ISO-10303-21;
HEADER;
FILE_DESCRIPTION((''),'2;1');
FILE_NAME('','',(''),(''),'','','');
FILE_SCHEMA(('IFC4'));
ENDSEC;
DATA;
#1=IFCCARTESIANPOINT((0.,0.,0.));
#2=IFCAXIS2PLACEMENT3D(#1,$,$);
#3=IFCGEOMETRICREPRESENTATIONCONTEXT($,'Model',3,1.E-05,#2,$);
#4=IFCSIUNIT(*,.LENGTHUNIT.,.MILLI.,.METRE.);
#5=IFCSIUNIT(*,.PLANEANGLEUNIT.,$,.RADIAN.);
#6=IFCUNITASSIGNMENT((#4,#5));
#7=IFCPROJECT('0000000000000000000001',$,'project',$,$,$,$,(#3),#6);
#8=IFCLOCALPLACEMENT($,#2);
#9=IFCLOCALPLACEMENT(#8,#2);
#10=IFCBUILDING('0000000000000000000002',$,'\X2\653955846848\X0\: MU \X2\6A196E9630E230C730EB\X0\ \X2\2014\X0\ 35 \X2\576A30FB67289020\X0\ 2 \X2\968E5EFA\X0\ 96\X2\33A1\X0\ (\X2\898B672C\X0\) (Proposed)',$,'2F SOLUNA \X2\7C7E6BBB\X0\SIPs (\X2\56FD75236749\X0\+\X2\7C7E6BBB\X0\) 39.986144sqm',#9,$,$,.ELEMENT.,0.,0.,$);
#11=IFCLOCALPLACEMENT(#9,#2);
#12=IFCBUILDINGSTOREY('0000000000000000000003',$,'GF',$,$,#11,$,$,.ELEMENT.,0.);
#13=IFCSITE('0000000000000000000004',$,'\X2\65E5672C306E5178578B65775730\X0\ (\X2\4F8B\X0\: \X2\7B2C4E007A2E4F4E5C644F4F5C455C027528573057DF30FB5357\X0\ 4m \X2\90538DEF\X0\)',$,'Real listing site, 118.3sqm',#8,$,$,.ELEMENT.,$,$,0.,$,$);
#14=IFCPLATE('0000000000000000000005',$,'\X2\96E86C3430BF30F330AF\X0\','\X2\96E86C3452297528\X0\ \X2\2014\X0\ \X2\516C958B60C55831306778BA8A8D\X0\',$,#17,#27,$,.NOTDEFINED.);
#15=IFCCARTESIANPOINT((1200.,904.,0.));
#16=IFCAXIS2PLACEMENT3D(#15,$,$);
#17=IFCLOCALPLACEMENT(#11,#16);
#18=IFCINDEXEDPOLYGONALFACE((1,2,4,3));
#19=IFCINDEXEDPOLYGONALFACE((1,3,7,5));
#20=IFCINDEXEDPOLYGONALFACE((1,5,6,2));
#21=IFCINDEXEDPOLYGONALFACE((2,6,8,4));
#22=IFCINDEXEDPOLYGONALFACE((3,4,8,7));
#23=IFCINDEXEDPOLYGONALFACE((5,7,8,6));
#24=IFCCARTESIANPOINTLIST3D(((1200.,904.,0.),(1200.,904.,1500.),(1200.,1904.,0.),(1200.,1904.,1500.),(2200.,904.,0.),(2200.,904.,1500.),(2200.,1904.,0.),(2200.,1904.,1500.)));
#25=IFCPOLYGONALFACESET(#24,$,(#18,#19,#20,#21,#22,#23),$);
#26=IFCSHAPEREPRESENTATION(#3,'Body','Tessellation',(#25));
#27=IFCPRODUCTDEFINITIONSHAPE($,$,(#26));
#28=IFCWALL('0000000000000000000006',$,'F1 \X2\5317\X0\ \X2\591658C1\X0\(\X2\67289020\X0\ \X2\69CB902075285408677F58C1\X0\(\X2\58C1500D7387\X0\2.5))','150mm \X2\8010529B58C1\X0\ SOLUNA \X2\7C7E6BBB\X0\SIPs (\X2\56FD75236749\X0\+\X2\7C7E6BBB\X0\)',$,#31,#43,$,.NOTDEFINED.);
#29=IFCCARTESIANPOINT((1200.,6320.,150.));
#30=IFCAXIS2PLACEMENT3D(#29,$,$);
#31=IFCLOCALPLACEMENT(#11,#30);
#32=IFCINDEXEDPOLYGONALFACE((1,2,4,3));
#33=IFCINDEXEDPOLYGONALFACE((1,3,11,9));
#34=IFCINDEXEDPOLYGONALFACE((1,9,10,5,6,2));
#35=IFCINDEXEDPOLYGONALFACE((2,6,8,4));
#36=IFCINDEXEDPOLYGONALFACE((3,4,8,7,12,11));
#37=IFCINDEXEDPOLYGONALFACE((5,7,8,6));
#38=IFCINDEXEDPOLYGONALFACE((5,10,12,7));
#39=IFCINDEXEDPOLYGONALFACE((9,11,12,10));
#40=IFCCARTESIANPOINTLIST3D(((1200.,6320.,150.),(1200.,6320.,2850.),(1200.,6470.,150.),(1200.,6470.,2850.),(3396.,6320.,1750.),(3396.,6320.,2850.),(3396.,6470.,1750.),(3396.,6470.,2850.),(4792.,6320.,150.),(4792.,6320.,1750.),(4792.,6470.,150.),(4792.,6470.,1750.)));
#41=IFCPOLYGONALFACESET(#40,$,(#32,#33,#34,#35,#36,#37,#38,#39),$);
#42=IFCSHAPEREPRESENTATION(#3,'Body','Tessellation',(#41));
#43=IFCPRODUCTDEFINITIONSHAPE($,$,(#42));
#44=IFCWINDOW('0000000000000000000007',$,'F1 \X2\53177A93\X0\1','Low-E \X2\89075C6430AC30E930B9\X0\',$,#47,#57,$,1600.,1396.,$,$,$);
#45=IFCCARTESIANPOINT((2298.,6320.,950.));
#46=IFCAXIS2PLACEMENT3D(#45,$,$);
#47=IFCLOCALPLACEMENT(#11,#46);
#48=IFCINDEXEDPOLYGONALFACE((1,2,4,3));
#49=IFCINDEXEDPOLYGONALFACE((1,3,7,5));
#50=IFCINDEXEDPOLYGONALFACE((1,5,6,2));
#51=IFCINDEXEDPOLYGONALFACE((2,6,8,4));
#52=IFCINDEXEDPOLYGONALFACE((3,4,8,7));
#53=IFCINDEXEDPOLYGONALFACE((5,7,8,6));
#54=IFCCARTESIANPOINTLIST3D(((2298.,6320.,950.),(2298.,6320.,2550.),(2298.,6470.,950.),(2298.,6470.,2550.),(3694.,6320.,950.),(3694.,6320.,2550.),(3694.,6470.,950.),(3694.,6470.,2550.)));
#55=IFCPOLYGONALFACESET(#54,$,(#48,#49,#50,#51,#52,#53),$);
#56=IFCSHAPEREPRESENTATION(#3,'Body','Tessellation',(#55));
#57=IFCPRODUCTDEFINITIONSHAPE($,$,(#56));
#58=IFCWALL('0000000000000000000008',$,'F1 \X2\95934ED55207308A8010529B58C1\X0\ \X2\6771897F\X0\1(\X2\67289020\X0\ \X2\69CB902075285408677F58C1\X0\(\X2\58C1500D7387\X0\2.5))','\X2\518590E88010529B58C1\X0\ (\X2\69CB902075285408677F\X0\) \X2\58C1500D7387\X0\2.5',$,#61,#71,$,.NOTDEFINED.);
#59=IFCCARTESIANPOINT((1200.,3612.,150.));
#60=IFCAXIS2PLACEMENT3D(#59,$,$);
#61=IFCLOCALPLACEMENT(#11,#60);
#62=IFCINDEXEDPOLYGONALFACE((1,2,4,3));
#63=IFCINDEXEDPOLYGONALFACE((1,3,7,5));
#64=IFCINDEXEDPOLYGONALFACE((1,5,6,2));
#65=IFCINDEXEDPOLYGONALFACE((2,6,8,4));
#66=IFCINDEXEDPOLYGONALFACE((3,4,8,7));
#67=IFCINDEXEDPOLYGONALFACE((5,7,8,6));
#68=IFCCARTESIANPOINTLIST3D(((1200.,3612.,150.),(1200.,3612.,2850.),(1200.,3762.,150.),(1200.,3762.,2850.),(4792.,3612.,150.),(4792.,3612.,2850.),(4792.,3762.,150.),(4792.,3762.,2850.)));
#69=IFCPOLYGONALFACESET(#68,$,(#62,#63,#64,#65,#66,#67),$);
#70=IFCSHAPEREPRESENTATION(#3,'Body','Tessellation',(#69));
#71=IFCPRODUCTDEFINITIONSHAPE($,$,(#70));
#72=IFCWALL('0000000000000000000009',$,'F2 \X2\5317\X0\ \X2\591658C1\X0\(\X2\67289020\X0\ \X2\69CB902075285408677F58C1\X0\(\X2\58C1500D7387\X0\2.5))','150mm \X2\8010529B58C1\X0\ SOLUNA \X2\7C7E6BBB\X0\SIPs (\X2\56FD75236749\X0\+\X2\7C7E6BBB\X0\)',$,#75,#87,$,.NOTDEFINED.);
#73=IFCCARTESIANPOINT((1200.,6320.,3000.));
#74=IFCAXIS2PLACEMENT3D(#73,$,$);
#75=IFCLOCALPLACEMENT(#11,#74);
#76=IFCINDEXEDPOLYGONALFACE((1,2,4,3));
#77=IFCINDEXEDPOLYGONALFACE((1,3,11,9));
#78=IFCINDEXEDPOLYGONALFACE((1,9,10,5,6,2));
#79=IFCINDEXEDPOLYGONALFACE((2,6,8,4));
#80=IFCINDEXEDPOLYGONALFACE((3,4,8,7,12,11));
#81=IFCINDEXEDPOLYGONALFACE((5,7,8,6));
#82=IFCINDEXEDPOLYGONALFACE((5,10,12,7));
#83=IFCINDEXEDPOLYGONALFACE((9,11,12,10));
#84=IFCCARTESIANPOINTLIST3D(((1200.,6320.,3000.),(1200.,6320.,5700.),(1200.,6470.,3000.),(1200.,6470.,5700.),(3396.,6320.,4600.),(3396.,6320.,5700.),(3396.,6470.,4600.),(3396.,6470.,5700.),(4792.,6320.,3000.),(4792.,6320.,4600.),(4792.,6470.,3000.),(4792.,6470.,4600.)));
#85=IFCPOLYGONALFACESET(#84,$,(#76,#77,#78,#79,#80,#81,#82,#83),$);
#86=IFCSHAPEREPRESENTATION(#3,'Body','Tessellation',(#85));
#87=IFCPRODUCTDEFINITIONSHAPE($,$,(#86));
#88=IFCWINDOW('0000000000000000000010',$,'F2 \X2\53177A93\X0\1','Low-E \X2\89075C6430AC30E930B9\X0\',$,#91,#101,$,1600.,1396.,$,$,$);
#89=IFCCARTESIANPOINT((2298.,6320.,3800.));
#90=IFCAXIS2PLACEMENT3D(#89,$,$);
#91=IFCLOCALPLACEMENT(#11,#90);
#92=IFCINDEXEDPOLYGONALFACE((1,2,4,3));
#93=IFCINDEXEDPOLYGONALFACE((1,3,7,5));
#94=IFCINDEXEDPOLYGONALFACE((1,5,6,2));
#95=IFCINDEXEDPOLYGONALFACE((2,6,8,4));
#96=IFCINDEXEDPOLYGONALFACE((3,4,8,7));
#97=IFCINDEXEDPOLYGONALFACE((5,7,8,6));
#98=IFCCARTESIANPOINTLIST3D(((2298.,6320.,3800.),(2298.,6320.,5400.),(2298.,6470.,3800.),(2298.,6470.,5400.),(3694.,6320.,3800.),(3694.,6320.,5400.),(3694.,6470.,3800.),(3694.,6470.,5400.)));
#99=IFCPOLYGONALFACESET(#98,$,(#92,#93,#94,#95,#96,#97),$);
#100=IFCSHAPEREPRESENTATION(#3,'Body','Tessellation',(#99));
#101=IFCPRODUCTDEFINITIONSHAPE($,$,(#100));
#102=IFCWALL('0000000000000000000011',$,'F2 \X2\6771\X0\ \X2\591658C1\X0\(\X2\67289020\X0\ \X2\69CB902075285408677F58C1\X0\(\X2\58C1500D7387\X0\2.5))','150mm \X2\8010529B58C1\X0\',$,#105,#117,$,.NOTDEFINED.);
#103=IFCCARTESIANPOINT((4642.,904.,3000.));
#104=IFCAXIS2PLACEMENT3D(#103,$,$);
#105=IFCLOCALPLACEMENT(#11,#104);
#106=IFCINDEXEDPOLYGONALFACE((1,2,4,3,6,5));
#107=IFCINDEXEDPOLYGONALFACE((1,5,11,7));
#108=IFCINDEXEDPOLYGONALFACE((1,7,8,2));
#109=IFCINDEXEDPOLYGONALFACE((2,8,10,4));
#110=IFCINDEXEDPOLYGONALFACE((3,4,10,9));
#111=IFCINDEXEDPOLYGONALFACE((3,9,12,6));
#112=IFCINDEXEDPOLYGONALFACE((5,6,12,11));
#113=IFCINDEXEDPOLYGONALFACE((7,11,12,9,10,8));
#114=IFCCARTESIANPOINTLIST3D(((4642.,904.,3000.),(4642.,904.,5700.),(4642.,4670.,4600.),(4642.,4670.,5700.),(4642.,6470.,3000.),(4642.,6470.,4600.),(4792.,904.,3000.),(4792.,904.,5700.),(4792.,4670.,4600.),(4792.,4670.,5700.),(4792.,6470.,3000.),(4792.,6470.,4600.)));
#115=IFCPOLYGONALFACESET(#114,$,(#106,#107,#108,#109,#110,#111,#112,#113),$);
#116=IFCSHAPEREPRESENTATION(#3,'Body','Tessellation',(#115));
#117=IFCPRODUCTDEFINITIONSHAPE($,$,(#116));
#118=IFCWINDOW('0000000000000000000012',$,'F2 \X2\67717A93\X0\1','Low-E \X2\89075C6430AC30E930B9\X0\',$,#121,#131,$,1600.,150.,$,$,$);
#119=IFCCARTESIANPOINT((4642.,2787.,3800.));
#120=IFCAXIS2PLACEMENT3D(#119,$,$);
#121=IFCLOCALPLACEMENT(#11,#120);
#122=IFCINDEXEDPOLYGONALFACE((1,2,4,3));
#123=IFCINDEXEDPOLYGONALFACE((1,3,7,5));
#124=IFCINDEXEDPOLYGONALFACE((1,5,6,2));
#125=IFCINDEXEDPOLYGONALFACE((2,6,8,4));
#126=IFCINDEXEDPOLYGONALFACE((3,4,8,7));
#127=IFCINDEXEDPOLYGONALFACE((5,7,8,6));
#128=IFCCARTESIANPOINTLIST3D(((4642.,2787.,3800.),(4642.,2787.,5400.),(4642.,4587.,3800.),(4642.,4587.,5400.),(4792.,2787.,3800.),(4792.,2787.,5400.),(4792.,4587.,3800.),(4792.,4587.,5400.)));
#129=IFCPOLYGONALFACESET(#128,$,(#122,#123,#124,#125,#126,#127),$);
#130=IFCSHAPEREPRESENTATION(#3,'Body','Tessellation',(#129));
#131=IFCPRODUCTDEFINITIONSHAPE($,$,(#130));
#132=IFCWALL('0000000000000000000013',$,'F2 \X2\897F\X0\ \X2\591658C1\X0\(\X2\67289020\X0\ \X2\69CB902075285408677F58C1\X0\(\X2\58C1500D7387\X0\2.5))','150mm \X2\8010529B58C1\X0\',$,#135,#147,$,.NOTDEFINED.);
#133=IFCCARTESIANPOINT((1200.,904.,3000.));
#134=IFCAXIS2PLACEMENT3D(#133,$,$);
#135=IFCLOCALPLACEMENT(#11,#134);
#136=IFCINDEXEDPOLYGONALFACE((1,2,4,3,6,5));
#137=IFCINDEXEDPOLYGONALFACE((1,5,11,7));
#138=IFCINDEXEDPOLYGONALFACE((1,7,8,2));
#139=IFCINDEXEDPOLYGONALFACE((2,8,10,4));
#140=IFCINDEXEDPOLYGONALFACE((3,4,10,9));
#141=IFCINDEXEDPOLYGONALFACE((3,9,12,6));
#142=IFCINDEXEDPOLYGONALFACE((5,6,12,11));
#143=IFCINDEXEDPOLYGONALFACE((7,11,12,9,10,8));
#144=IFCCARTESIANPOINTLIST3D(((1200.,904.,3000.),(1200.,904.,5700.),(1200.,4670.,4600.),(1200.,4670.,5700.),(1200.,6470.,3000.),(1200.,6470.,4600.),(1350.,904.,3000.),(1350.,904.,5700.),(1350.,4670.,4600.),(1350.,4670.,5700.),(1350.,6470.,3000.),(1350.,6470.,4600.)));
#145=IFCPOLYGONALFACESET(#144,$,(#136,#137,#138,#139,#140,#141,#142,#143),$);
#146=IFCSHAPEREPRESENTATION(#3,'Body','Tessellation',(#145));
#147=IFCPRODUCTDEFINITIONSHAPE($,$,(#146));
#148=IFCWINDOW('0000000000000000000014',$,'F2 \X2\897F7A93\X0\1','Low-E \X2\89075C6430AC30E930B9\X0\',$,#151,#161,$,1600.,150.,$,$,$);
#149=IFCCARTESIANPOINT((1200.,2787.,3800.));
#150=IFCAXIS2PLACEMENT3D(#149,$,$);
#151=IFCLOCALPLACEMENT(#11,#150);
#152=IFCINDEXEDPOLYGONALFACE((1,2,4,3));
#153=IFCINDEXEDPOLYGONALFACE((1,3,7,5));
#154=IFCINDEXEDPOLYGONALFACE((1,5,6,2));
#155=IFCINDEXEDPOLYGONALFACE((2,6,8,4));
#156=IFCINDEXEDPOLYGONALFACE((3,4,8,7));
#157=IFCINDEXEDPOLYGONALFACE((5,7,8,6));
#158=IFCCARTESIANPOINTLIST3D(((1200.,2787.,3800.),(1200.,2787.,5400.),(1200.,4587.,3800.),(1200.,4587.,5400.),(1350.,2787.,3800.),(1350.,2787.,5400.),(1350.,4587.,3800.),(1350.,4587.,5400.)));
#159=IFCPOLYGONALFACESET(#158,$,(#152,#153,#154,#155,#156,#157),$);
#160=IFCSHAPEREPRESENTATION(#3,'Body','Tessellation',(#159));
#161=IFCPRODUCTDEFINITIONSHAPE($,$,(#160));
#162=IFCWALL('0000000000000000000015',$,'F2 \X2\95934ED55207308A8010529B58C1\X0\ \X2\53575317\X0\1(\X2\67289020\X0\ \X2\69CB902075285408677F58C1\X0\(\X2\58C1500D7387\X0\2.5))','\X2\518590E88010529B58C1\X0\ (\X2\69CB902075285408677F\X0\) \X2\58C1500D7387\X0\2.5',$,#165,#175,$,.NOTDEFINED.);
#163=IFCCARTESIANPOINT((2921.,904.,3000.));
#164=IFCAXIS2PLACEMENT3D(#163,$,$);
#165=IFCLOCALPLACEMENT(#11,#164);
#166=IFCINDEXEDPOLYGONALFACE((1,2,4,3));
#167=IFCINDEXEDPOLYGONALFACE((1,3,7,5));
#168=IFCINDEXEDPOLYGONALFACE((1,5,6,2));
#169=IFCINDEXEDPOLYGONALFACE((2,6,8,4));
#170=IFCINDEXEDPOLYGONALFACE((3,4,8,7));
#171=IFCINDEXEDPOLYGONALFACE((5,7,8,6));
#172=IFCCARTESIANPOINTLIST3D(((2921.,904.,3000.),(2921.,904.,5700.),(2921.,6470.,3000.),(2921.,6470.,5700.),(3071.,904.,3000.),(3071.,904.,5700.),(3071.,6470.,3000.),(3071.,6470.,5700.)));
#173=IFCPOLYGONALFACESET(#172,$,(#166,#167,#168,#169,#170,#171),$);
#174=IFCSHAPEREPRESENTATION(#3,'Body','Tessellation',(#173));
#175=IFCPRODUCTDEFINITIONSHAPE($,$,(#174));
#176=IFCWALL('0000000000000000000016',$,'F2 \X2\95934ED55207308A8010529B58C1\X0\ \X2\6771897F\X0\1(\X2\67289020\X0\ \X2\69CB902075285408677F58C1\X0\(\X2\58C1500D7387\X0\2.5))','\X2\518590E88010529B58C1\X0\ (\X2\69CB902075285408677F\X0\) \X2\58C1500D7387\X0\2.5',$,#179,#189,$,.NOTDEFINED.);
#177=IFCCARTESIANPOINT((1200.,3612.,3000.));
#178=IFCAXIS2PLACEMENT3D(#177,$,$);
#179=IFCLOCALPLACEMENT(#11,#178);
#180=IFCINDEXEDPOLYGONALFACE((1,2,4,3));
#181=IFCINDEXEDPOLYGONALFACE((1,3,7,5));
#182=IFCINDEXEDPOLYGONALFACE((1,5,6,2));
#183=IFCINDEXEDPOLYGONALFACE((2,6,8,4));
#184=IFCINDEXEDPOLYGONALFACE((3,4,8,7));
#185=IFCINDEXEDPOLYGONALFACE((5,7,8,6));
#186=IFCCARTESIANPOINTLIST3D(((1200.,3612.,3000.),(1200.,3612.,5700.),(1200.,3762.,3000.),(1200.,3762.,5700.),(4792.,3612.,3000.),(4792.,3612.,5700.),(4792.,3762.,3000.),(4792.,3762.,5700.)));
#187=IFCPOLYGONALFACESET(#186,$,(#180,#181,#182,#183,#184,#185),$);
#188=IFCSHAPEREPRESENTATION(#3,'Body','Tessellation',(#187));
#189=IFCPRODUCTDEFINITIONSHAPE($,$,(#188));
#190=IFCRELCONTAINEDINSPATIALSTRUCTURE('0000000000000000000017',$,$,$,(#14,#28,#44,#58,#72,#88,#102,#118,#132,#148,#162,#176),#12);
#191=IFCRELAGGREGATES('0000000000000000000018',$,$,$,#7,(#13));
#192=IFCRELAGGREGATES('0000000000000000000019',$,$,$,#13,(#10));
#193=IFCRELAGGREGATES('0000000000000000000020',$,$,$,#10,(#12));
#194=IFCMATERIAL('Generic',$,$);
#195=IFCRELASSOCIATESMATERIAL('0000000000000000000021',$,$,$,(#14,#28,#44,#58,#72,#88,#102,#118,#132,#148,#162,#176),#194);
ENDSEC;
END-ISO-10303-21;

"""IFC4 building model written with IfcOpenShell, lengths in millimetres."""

from ifc_helpers import new_model, si_unit, frame, frame_2d, origin, place, context, project, spatial, rectangle, extrude, material, element, fill, save


model = new_model("IFC4")

# Units and contexts
model_context = context("Model", 3, precision=1e-05, world=origin())
ifc_project = project(units=[si_unit("LENGTHUNIT", "METRE", prefix="MILLI"), si_unit("PLANEANGLEUNIT", "RADIAN")], contexts=[model_context])

# Site, building, storey
site_placement = place(None, origin())
site = spatial("IfcSite", under=ifc_project, at=site_placement, Name="日本の典型敷地 (例: 第一種低層住居専用地域・南 4m 道路)", ObjectType="Real listing site, 118.3sqm", CompositionType="ELEMENT", RefElevation=0.0)
building_placement = place(site_placement, origin())
building = spatial("IfcBuilding", under=site, at=building_placement, Name="改善案: MU 標準モデル — 35 坪・木造 2 階建 96㎡ (見本) (Proposed)", ObjectType="2F SOLUNA 籾殻SIPs (国産杉+籾殻) 39.986144sqm", CompositionType="ELEMENT", ElevationOfRefHeight=0.0, ElevationOfTerrain=0.0)
storey_placement = place(building_placement, origin())
storey = spatial("IfcBuildingStorey", under=building, at=storey_placement, Name="GF", CompositionType="ELEMENT", Elevation=0.0)

# Plate
ifc_material_1 = material(Name="Generic")
plate_placement = place(storey_placement, frame((1200.0, 904.0, 0.0)))
element("IfcPlate", 1, at=plate_placement, inside=storey, material=ifc_material_1, Name="雨水タンク", Description="雨水利用 — 公開情報で確認", PredefinedType="NOTDEFINED", context=model_context, shape_type="SweptSolid", body=[
    extrude(rectangle(XDim=1000.0, YDim=1000.0, at=frame_2d((500.0, 500.0))), frame((1200.0, 904.0, 0.0)), (0.0, 0.0, 1.0), 1500.0),
])

# Wall, opening, window
wall_1_placement = place(storey_placement, frame((1200.0, 6320.0, 150.0)))
wall_1 = element("IfcWall", 2, at=wall_1_placement, inside=storey, material=ifc_material_1, Name="F1 北 外壁(木造 構造用合板壁(壁倍率2.5))", Description="150mm 耐力壁 SOLUNA 籾殻SIPs (国産杉+籾殻)", PredefinedType="NOTDEFINED", context=model_context, shape_type="SweptSolid", body=[
    extrude(rectangle(XDim=3592.0, YDim=150.0, at=frame_2d((1796.0, 75.0))), frame((1200.0, 6320.0, 150.0)), (0.0, 0.0, 1.0), 2700.0),
])
opening_1_placement = place(storey_placement, frame((2298.0, 6320.0, 950.0)))
opening_1 = element("IfcOpeningElement", 3, at=opening_1_placement, cuts=wall_1, PredefinedType="NOTDEFINED", context=model_context, shape_type="SweptSolid", body=[
    extrude(rectangle(XDim=1396.0, YDim=150.0, at=frame_2d((698.0, 75.0))), frame((2298.0, 6320.0, 950.0)), (0.0, 0.0, 1.0), 1600.0),
])
window_1_placement = place(storey_placement, frame((2298.0, 6320.0, 950.0)))
window_1 = element("IfcWindow", 4, at=window_1_placement, inside=storey, material=ifc_material_1, Name="F1 北窓1", Description="Low-E 複層ガラス", OverallHeight=1600.0, OverallWidth=1396.0, context=model_context, shape_type="SweptSolid", body=[
    extrude(rectangle(XDim=1396.0, YDim=150.0, at=frame_2d((698.0, 75.0))), frame((2298.0, 6320.0, 950.0)), (0.0, 0.0, 1.0), 1600.0),
])
fill(opening_1, window_1)

# Wall
wall_2_placement = place(storey_placement, frame((1200.0, 3612.0, 150.0)))
element("IfcWall", 5, at=wall_2_placement, inside=storey, material=ifc_material_1, Name="F1 間仕切り耐力壁 東西1(木造 構造用合板壁(壁倍率2.5))", Description="内部耐力壁 (構造用合板) 壁倍率2.5", PredefinedType="NOTDEFINED", context=model_context, shape_type="SweptSolid", body=[
    extrude(rectangle(XDim=3592.0, YDim=150.0, at=frame_2d((1796.0, 75.0))), frame((1200.0, 3612.0, 150.0)), (0.0, 0.0, 1.0), 2700.0),
])

# Walls, openings, windows
wall_3_placement = place(storey_placement, frame((1200.0, 6320.0, 3000.0)))
wall_3 = element("IfcWall", 6, at=wall_3_placement, inside=storey, material=ifc_material_1, Name="F2 北 外壁(木造 構造用合板壁(壁倍率2.5))", Description="150mm 耐力壁 SOLUNA 籾殻SIPs (国産杉+籾殻)", PredefinedType="NOTDEFINED", context=model_context, shape_type="SweptSolid", body=[
    extrude(rectangle(XDim=3592.0, YDim=150.0, at=frame_2d((1796.0, 75.0))), frame((1200.0, 6320.0, 3000.0)), (0.0, 0.0, 1.0), 2700.0),
])
opening_2_placement = place(storey_placement, frame((2298.0, 6320.0, 3800.0)))
opening_2 = element("IfcOpeningElement", 7, at=opening_2_placement, cuts=wall_3, PredefinedType="NOTDEFINED", context=model_context, shape_type="SweptSolid", body=[
    extrude(rectangle(XDim=1396.0, YDim=150.0, at=frame_2d((698.0, 75.0))), frame((2298.0, 6320.0, 3800.0)), (0.0, 0.0, 1.0), 1600.0),
])
window_2_placement = place(storey_placement, frame((2298.0, 6320.0, 3800.0)))
window_2 = element("IfcWindow", 8, at=window_2_placement, inside=storey, material=ifc_material_1, Name="F2 北窓1", Description="Low-E 複層ガラス", OverallHeight=1600.0, OverallWidth=1396.0, context=model_context, shape_type="SweptSolid", body=[
    extrude(rectangle(XDim=1396.0, YDim=150.0, at=frame_2d((698.0, 75.0))), frame((2298.0, 6320.0, 3800.0)), (0.0, 0.0, 1.0), 1600.0),
])
fill(opening_2, window_2)
wall_4_placement = place(storey_placement, frame((4642.0, 904.0, 3000.0)))
wall_4 = element("IfcWall", 9, at=wall_4_placement, inside=storey, material=ifc_material_1, Name="F2 東 外壁(木造 構造用合板壁(壁倍率2.5))", Description="150mm 耐力壁", PredefinedType="NOTDEFINED", context=model_context, shape_type="SweptSolid", body=[
    extrude(rectangle(XDim=150.0, YDim=5566.0, at=frame_2d((75.0, 2783.0))), frame((4642.0, 904.0, 3000.0)), (0.0, 0.0, 1.0), 2700.0),
])
opening_3_placement = place(storey_placement, frame((4642.0, 2787.0, 3800.0)))
opening_3 = element("IfcOpeningElement", 10, at=opening_3_placement, cuts=wall_4, PredefinedType="NOTDEFINED", context=model_context, shape_type="SweptSolid", body=[
    extrude(rectangle(XDim=150.0, YDim=1800.0, at=frame_2d((75.0, 900.0))), frame((4642.0, 2787.0, 3800.0)), (0.0, 0.0, 1.0), 1600.0),
])
window_3_placement = place(storey_placement, frame((4642.0, 2787.0, 3800.0)))
window_3 = element("IfcWindow", 11, at=window_3_placement, inside=storey, material=ifc_material_1, Name="F2 東窓1", Description="Low-E 複層ガラス", OverallHeight=1600.0, OverallWidth=150.0, context=model_context, shape_type="SweptSolid", body=[
    extrude(rectangle(XDim=150.0, YDim=1800.0, at=frame_2d((75.0, 900.0))), frame((4642.0, 2787.0, 3800.0)), (0.0, 0.0, 1.0), 1600.0),
])
fill(opening_3, window_3)
wall_5_placement = place(storey_placement, frame((1200.0, 904.0, 3000.0)))
wall_5 = element("IfcWall", 12, at=wall_5_placement, inside=storey, material=ifc_material_1, Name="F2 西 外壁(木造 構造用合板壁(壁倍率2.5))", Description="150mm 耐力壁", PredefinedType="NOTDEFINED", context=model_context, shape_type="SweptSolid", body=[
    extrude(rectangle(XDim=150.0, YDim=5566.0, at=frame_2d((75.0, 2783.0))), frame((1200.0, 904.0, 3000.0)), (0.0, 0.0, 1.0), 2700.0),
])
opening_4_placement = place(storey_placement, frame((1200.0, 2787.0, 3800.0)))
opening_4 = element("IfcOpeningElement", 13, at=opening_4_placement, cuts=wall_5, PredefinedType="NOTDEFINED", context=model_context, shape_type="SweptSolid", body=[
    extrude(rectangle(XDim=150.0, YDim=1800.0, at=frame_2d((75.0, 900.0))), frame((1200.0, 2787.0, 3800.0)), (0.0, 0.0, 1.0), 1600.0),
])
window_4_placement = place(storey_placement, frame((1200.0, 2787.0, 3800.0)))
window_4 = element("IfcWindow", 14, at=window_4_placement, inside=storey, material=ifc_material_1, Name="F2 西窓1", Description="Low-E 複層ガラス", OverallHeight=1600.0, OverallWidth=150.0, context=model_context, shape_type="SweptSolid", body=[
    extrude(rectangle(XDim=150.0, YDim=1800.0, at=frame_2d((75.0, 900.0))), frame((1200.0, 2787.0, 3800.0)), (0.0, 0.0, 1.0), 1600.0),
])
fill(opening_4, window_4)

# Walls
wall_6_placement = place(storey_placement, frame((2921.0, 904.0, 3000.0)))
element("IfcWall", 15, at=wall_6_placement, inside=storey, material=ifc_material_1, Name="F2 間仕切り耐力壁 南北1(木造 構造用合板壁(壁倍率2.5))", Description="内部耐力壁 (構造用合板) 壁倍率2.5", PredefinedType="NOTDEFINED", context=model_context, shape_type="SweptSolid", body=[
    extrude(rectangle(XDim=150.0, YDim=5566.0, at=frame_2d((75.0, 2783.0))), frame((2921.0, 904.0, 3000.0)), (0.0, 0.0, 1.0), 2700.0),
])
wall_7_placement = place(storey_placement, frame((1200.0, 3612.0, 3000.0)))
element("IfcWall", 16, at=wall_7_placement, inside=storey, material=ifc_material_1, Name="F2 間仕切り耐力壁 東西1(木造 構造用合板壁(壁倍率2.5))", Description="内部耐力壁 (構造用合板) 壁倍率2.5", PredefinedType="NOTDEFINED", context=model_context, shape_type="SweptSolid", body=[
    extrude(rectangle(XDim=3592.0, YDim=150.0, at=frame_2d((1796.0, 75.0))), frame((1200.0, 3612.0, 3000.0)), (0.0, 0.0, 1.0), 2700.0),
])

save(model, "model.ifc")
